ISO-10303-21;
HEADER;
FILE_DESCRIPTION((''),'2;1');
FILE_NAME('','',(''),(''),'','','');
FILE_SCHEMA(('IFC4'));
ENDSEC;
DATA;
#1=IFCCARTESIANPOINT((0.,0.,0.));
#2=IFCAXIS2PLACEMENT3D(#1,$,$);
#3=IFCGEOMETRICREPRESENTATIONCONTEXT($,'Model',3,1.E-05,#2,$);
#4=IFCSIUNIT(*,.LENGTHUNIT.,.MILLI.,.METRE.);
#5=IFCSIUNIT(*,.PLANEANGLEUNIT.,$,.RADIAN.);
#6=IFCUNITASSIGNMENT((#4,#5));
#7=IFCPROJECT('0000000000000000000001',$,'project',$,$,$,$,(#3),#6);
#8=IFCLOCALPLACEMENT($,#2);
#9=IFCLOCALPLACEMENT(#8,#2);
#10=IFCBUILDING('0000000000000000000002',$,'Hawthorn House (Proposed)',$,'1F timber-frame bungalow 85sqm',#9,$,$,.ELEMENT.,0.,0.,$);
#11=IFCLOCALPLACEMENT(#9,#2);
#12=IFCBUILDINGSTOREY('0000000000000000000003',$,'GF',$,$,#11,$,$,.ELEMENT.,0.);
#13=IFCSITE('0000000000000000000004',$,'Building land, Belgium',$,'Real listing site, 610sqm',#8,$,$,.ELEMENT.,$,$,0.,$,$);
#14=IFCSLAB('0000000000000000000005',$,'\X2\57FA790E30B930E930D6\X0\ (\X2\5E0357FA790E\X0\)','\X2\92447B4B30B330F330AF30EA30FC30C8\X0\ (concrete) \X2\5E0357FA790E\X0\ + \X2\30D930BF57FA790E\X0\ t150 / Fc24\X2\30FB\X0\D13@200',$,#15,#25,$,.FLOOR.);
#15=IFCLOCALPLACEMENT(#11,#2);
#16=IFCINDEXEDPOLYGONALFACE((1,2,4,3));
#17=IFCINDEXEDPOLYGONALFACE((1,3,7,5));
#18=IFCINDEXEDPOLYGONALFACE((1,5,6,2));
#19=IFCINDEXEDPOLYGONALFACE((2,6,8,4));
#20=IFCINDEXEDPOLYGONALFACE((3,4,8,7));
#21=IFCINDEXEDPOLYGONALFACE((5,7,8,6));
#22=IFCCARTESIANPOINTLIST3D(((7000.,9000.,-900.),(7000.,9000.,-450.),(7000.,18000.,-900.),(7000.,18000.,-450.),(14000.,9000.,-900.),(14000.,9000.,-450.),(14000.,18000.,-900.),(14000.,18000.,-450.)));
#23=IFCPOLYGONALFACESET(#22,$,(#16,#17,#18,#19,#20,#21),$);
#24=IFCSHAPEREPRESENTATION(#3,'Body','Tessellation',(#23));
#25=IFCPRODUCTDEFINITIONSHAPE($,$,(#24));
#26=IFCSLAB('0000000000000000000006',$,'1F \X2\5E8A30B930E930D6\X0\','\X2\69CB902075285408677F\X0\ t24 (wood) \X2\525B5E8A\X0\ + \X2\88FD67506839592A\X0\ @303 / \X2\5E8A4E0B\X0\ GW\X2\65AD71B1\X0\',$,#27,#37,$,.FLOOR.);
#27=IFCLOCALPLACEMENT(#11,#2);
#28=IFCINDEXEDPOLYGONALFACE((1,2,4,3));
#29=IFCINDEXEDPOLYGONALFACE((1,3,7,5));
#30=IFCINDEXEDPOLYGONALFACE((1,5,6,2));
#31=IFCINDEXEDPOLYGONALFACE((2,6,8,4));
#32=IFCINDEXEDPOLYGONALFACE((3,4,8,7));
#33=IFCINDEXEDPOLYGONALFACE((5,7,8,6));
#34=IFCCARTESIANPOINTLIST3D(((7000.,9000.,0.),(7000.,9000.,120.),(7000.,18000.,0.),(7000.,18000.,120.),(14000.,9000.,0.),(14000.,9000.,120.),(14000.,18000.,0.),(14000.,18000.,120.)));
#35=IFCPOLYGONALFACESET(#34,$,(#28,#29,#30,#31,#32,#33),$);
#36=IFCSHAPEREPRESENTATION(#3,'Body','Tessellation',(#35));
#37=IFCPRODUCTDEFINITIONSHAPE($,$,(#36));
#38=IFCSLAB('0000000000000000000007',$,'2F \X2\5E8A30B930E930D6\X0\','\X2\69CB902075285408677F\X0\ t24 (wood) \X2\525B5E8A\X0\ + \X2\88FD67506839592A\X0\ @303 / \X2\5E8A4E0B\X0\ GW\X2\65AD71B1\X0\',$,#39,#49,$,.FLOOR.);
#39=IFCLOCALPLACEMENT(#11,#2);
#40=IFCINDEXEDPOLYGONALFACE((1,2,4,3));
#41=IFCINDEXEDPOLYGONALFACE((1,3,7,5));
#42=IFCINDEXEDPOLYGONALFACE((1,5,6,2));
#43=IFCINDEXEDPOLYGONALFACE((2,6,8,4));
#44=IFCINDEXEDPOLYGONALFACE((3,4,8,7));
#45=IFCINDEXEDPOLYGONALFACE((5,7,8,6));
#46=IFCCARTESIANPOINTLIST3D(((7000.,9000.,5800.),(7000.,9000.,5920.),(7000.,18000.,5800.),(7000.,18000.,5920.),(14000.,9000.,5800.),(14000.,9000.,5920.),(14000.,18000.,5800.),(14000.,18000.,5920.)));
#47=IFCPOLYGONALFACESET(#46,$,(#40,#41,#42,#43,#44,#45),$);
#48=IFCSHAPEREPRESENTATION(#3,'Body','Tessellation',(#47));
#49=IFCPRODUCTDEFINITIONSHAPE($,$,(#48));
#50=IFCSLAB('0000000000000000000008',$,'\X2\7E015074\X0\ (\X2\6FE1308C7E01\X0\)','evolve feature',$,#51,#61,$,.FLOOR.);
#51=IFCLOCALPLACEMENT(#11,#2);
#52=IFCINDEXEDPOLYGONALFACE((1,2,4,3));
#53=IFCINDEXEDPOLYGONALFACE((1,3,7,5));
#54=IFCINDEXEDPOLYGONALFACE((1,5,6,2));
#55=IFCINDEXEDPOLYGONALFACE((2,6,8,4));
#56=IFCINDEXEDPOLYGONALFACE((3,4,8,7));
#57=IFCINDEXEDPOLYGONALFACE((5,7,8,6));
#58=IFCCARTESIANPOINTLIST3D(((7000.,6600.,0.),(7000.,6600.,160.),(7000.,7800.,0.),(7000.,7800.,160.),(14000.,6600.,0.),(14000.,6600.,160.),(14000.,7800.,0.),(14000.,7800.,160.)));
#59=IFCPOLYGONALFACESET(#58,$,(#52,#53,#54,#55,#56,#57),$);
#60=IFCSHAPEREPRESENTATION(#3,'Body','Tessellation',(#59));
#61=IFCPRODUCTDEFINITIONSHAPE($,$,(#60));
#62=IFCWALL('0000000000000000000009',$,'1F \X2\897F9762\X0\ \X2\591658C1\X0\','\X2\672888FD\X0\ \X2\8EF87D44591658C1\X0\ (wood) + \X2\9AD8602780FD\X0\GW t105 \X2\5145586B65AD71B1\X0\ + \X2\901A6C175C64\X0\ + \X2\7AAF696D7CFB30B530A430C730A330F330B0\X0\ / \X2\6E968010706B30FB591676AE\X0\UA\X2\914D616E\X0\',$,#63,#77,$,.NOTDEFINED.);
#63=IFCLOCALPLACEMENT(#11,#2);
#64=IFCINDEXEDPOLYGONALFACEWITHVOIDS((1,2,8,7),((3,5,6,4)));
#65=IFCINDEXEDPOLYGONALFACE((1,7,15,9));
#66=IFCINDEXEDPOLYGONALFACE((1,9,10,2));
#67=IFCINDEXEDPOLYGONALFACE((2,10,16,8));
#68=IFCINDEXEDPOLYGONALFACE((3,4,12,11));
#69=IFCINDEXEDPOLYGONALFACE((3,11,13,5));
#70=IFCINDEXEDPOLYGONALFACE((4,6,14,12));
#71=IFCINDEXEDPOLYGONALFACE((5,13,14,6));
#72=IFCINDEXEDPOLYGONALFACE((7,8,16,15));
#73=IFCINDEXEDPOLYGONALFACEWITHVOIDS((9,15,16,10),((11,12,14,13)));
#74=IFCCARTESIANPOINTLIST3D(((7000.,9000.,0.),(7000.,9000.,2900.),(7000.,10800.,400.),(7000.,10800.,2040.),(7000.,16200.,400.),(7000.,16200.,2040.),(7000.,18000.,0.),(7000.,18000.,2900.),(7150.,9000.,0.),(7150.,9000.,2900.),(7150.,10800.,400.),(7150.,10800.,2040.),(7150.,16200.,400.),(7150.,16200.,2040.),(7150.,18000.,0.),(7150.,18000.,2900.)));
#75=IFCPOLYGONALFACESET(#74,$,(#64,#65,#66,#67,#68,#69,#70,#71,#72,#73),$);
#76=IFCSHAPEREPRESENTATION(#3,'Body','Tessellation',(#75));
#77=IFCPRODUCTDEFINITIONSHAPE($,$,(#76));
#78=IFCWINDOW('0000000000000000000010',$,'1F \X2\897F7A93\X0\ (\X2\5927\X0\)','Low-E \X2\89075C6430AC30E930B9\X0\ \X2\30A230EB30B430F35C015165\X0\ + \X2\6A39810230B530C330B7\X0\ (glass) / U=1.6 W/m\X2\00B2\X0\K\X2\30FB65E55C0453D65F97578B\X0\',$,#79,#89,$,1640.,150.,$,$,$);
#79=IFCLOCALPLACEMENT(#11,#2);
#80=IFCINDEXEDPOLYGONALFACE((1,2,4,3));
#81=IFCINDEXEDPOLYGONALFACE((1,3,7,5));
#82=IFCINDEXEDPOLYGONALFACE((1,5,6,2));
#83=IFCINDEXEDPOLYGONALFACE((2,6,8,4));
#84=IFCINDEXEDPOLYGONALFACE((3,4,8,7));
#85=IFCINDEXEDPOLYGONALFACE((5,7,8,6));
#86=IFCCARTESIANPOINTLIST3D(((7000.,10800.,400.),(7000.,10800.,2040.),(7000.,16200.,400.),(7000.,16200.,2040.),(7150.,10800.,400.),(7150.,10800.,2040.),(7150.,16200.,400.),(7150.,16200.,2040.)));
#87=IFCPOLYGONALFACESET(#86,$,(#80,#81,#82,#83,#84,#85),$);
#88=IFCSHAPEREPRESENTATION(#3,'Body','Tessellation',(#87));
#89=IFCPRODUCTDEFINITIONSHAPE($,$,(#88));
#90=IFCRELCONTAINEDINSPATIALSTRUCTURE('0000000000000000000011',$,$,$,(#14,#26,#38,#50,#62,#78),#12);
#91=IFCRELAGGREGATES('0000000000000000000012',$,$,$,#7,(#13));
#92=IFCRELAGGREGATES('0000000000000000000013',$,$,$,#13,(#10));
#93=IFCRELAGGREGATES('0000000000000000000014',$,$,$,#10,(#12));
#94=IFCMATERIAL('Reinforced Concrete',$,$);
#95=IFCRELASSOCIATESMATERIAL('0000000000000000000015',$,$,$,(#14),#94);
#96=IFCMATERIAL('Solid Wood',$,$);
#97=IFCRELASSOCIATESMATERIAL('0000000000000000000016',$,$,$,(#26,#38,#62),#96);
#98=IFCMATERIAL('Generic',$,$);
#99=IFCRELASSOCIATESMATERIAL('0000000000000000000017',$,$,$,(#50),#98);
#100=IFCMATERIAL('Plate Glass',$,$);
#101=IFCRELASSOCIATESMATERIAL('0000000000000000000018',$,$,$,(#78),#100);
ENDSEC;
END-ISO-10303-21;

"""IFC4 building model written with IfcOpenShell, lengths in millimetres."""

from ifc_helpers import new_model, si_unit, frame, frame_2d, origin, place, context, project, spatial, rectangle, extrude, material, element, fill, save


model = new_model("IFC4")

# Units and contexts
model_context = context("Model", 3, precision=1e-05, world=origin())
ifc_project = project(units=[si_unit("LENGTHUNIT", "METRE", prefix="MILLI"), si_unit("PLANEANGLEUNIT", "RADIAN")], contexts=[model_context])

# Site, building, storey
site_placement = place(None, origin())
site = spatial("IfcSite", under=ifc_project, at=site_placement, Name="Building land, Belgium", ObjectType="Real listing site, 610sqm", CompositionType="ELEMENT", RefElevation=0.0)
building_placement = place(site_placement, origin())
building = spatial("IfcBuilding", under=site, at=building_placement, Name="Hawthorn House (Proposed)", ObjectType="1F timber-frame bungalow 85sqm", CompositionType="ELEMENT", ElevationOfRefHeight=0.0, ElevationOfTerrain=0.0)
storey_placement = place(building_placement, origin())
storey = spatial("IfcBuildingStorey", under=building, at=storey_placement, Name="GF", CompositionType="ELEMENT", Elevation=0.0)

# Slabs
ifc_material_1 = material(Name="Reinforced Concrete")
slab_1_placement = place(storey_placement, frame((3500.0, 4500.0, -450.0)))
element("IfcSlab", 1, at=slab_1_placement, inside=storey, material=ifc_material_1, Name="基礎スラブ (布基礎)", Description="鉄筋コンクリート (concrete) 布基礎 + ベタ基礎 t150 / Fc24・D13@200", PredefinedType="FLOOR", context=model_context, shape_type="SweptSolid", body=[
    extrude(rectangle(XDim=7000.0, YDim=9000.0, at=frame_2d((3500.0, 4500.0))), frame((3500.0, 4500.0, -450.0)), (0.0, 0.0, 1.0), 450.0),
])
ifc_material_2 = material(Name="Solid Wood")
slab_2_placement = place(storey_placement, frame((3500.0, 4500.0, 0.0)))
element("IfcSlab", 2, at=slab_2_placement, inside=storey, material=ifc_material_2, Name="1F 床スラブ", Description="構造用合板 t24 (wood) 剛床 + 製材根太 @303 / 床下 GW断熱", PredefinedType="FLOOR", context=model_context, shape_type="SweptSolid", body=[
    extrude(rectangle(XDim=7000.0, YDim=9000.0, at=frame_2d((3500.0, 4500.0))), frame((3500.0, 4500.0, 0.0)), (0.0, 0.0, 1.0), 120.0),
])
slab_3_placement = place(storey_placement, frame((3500.0, 4500.0, 2900.0)))
element("IfcSlab", 3, at=slab_3_placement, inside=storey, material=ifc_material_2, Name="2F 床スラブ", Description="構造用合板 t24 (wood) 剛床 + 製材根太 @303 / 床下 GW断熱", PredefinedType="FLOOR", context=model_context, shape_type="SweptSolid", body=[
    extrude(rectangle(XDim=7000.0, YDim=9000.0, at=frame_2d((3500.0, 4500.0))), frame((3500.0, 4500.0, 2900.0)), (0.0, 0.0, 1.0), 120.0),
])
ifc_material_3 = material(Name="Generic")
slab_4_placement = place(storey_placement, frame((3500.0, 3300.0, 0.0)))
element("IfcSlab", 4, at=slab_4_placement, inside=storey, material=ifc_material_3, Name="縁側 (濡れ縁)", Description="evolve feature", PredefinedType="FLOOR", context=model_context, shape_type="SweptSolid", body=[
    extrude(rectangle(XDim=7000.0, YDim=1200.0, at=frame_2d((3500.0, 600.0))), frame((3500.0, 3300.0, 0.0)), (0.0, 0.0, 1.0), 160.0),
])

# Shared definitions
ifc_material_4 = material(Name="Plate Glass")

# Wall, opening, window
wall_1_placement = place(storey_placement, frame((3500.0, 4500.0, 0.0)))
wall_1 = element("IfcWall", 5, at=wall_1_placement, inside=storey, material=ifc_material_2, Name="1F 西面 外壁", Description="木製 軸組外壁 (wood) + 高性能GW t105 充填断熱 + 通気層 + 窯業系サイディング / 準耐火・外皮UA配慮", PredefinedType="NOTDEFINED", context=model_context, shape_type="SweptSolid", body=[
    extrude(rectangle(XDim=150.0, YDim=9000.0, at=frame_2d((75.0, 4500.0))), frame((3500.0, 4500.0, 0.0)), (0.0, 0.0, 1.0), 2900.0),
])
opening_1_placement = place(storey_placement, frame((3500.0, 5400.0, 200.0)))
opening_1 = element("IfcOpeningElement", 6, at=opening_1_placement, cuts=wall_1, PredefinedType="NOTDEFINED", context=model_context, shape_type="SweptSolid", body=[
    extrude(rectangle(XDim=150.0, YDim=5400.0, at=frame_2d((75.0, 2700.0))), frame((3500.0, 5400.0, 200.0)), (0.0, 0.0, 1.0), 1640.0),
])
window_1_placement = place(storey_placement, frame((3500.0, 5400.0, 200.0)))
window_1 = element("IfcWindow", 7, at=window_1_placement, inside=storey, material=ifc_material_4, Name="1F 西窓 (大)", Description="Low-E 複層ガラス アルゴン封入 + 樹脂サッシ (glass) / U=1.6 W/m²K・日射取得型", OverallHeight=1640.0, OverallWidth=150.0, context=model_context, shape_type="SweptSolid", body=[
    extrude(rectangle(XDim=150.0, YDim=5400.0, at=frame_2d((75.0, 2700.0))), frame((3500.0, 5400.0, 200.0)), (0.0, 0.0, 1.0), 1640.0),
])
fill(opening_1, window_1)

save(model, "model.ifc")
